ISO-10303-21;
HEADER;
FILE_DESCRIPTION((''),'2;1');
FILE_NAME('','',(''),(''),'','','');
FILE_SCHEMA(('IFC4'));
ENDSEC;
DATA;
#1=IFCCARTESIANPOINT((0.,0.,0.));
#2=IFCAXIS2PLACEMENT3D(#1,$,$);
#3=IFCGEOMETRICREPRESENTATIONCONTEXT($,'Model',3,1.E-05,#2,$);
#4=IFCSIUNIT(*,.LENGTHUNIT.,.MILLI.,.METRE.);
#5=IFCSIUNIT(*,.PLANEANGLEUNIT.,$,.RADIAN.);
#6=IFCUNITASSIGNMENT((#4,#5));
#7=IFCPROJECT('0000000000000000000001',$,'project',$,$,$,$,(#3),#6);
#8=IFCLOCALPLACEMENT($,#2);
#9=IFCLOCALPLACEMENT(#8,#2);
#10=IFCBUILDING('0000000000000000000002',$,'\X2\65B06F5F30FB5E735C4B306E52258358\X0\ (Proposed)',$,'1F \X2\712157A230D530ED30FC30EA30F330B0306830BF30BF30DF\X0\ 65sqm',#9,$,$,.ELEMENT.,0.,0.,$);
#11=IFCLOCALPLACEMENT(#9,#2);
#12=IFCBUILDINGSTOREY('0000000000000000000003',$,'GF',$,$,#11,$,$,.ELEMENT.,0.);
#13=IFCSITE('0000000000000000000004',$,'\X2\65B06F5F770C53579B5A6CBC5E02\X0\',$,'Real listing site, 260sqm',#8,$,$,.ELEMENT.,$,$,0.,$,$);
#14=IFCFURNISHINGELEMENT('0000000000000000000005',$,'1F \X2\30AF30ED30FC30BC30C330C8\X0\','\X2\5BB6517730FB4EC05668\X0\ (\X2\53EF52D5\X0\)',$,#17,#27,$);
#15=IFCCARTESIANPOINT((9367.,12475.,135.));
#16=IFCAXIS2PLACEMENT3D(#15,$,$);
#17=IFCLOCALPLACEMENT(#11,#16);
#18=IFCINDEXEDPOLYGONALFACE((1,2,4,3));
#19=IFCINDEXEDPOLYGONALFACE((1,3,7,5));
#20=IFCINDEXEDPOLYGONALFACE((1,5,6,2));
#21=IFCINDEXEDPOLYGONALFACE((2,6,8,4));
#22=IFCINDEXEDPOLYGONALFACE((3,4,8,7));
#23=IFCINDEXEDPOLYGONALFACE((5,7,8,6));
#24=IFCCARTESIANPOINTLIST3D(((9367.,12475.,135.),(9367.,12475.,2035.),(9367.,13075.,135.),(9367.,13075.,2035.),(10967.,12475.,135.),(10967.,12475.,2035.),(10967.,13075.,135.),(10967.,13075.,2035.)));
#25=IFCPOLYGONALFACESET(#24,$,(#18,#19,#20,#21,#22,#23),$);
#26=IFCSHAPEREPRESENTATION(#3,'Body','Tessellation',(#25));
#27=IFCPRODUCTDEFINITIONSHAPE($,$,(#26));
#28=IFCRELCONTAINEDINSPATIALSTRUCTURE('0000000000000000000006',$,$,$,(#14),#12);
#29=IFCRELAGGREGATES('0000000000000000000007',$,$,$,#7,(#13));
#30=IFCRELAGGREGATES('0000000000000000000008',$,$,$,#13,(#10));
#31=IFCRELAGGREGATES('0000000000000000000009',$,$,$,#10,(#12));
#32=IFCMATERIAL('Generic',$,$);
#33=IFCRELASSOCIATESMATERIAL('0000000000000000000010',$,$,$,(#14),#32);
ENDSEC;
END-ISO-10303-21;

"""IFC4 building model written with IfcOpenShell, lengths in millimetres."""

from ifc_helpers import new_model, si_unit, frame, frame_2d, origin, place, context, project, spatial, rectangle, extrude, material, element, save


model = new_model("IFC4")

# Units and contexts
model_context = context("Model", 3, precision=1e-05, world=origin())
ifc_project = project(units=[si_unit("LENGTHUNIT", "METRE", prefix="MILLI"), si_unit("PLANEANGLEUNIT", "RADIAN")], contexts=[model_context])

# Site, building, storey
site_placement = place(None, origin())
site = spatial("IfcSite", under=ifc_project, at=site_placement, Name="新潟県南魚沼市", ObjectType="Real listing site, 260sqm", CompositionType="ELEMENT", RefElevation=0.0)
building_placement = place(site_placement, origin())
building = spatial("IfcBuilding", under=site, at=building_placement, Name="新潟・平屋の別荘 (Proposed)", ObjectType="1F 無垢フローリングとタタミ 65sqm", CompositionType="ELEMENT", ElevationOfRefHeight=0.0, ElevationOfTerrain=0.0)
storey_placement = place(building_placement, origin())
storey = spatial("IfcBuildingStorey", under=building, at=storey_placement, Name="GF", CompositionType="ELEMENT", Elevation=0.0)

# Shared definitions
ifc_material_1 = material(Name="Generic")

# Furnishing element
furnishing_placement = place(storey_placement, frame((9367.0, 12475.0, 135.0)))
element("IfcFurnishingElement", 1, at=furnishing_placement, inside=storey, material=ifc_material_1, Name="1F クローゼット", Description="家具・什器 (可動)", context=model_context, shape_type="SweptSolid", body=[
    extrude(rectangle(XDim=1600.0, YDim=600.0, at=frame_2d((800.0, 300.0))), frame((9367.0, 12475.0, 135.0)), (0.0, 0.0, 1.0), 1900.0),
])

save(model, "model.ifc")
